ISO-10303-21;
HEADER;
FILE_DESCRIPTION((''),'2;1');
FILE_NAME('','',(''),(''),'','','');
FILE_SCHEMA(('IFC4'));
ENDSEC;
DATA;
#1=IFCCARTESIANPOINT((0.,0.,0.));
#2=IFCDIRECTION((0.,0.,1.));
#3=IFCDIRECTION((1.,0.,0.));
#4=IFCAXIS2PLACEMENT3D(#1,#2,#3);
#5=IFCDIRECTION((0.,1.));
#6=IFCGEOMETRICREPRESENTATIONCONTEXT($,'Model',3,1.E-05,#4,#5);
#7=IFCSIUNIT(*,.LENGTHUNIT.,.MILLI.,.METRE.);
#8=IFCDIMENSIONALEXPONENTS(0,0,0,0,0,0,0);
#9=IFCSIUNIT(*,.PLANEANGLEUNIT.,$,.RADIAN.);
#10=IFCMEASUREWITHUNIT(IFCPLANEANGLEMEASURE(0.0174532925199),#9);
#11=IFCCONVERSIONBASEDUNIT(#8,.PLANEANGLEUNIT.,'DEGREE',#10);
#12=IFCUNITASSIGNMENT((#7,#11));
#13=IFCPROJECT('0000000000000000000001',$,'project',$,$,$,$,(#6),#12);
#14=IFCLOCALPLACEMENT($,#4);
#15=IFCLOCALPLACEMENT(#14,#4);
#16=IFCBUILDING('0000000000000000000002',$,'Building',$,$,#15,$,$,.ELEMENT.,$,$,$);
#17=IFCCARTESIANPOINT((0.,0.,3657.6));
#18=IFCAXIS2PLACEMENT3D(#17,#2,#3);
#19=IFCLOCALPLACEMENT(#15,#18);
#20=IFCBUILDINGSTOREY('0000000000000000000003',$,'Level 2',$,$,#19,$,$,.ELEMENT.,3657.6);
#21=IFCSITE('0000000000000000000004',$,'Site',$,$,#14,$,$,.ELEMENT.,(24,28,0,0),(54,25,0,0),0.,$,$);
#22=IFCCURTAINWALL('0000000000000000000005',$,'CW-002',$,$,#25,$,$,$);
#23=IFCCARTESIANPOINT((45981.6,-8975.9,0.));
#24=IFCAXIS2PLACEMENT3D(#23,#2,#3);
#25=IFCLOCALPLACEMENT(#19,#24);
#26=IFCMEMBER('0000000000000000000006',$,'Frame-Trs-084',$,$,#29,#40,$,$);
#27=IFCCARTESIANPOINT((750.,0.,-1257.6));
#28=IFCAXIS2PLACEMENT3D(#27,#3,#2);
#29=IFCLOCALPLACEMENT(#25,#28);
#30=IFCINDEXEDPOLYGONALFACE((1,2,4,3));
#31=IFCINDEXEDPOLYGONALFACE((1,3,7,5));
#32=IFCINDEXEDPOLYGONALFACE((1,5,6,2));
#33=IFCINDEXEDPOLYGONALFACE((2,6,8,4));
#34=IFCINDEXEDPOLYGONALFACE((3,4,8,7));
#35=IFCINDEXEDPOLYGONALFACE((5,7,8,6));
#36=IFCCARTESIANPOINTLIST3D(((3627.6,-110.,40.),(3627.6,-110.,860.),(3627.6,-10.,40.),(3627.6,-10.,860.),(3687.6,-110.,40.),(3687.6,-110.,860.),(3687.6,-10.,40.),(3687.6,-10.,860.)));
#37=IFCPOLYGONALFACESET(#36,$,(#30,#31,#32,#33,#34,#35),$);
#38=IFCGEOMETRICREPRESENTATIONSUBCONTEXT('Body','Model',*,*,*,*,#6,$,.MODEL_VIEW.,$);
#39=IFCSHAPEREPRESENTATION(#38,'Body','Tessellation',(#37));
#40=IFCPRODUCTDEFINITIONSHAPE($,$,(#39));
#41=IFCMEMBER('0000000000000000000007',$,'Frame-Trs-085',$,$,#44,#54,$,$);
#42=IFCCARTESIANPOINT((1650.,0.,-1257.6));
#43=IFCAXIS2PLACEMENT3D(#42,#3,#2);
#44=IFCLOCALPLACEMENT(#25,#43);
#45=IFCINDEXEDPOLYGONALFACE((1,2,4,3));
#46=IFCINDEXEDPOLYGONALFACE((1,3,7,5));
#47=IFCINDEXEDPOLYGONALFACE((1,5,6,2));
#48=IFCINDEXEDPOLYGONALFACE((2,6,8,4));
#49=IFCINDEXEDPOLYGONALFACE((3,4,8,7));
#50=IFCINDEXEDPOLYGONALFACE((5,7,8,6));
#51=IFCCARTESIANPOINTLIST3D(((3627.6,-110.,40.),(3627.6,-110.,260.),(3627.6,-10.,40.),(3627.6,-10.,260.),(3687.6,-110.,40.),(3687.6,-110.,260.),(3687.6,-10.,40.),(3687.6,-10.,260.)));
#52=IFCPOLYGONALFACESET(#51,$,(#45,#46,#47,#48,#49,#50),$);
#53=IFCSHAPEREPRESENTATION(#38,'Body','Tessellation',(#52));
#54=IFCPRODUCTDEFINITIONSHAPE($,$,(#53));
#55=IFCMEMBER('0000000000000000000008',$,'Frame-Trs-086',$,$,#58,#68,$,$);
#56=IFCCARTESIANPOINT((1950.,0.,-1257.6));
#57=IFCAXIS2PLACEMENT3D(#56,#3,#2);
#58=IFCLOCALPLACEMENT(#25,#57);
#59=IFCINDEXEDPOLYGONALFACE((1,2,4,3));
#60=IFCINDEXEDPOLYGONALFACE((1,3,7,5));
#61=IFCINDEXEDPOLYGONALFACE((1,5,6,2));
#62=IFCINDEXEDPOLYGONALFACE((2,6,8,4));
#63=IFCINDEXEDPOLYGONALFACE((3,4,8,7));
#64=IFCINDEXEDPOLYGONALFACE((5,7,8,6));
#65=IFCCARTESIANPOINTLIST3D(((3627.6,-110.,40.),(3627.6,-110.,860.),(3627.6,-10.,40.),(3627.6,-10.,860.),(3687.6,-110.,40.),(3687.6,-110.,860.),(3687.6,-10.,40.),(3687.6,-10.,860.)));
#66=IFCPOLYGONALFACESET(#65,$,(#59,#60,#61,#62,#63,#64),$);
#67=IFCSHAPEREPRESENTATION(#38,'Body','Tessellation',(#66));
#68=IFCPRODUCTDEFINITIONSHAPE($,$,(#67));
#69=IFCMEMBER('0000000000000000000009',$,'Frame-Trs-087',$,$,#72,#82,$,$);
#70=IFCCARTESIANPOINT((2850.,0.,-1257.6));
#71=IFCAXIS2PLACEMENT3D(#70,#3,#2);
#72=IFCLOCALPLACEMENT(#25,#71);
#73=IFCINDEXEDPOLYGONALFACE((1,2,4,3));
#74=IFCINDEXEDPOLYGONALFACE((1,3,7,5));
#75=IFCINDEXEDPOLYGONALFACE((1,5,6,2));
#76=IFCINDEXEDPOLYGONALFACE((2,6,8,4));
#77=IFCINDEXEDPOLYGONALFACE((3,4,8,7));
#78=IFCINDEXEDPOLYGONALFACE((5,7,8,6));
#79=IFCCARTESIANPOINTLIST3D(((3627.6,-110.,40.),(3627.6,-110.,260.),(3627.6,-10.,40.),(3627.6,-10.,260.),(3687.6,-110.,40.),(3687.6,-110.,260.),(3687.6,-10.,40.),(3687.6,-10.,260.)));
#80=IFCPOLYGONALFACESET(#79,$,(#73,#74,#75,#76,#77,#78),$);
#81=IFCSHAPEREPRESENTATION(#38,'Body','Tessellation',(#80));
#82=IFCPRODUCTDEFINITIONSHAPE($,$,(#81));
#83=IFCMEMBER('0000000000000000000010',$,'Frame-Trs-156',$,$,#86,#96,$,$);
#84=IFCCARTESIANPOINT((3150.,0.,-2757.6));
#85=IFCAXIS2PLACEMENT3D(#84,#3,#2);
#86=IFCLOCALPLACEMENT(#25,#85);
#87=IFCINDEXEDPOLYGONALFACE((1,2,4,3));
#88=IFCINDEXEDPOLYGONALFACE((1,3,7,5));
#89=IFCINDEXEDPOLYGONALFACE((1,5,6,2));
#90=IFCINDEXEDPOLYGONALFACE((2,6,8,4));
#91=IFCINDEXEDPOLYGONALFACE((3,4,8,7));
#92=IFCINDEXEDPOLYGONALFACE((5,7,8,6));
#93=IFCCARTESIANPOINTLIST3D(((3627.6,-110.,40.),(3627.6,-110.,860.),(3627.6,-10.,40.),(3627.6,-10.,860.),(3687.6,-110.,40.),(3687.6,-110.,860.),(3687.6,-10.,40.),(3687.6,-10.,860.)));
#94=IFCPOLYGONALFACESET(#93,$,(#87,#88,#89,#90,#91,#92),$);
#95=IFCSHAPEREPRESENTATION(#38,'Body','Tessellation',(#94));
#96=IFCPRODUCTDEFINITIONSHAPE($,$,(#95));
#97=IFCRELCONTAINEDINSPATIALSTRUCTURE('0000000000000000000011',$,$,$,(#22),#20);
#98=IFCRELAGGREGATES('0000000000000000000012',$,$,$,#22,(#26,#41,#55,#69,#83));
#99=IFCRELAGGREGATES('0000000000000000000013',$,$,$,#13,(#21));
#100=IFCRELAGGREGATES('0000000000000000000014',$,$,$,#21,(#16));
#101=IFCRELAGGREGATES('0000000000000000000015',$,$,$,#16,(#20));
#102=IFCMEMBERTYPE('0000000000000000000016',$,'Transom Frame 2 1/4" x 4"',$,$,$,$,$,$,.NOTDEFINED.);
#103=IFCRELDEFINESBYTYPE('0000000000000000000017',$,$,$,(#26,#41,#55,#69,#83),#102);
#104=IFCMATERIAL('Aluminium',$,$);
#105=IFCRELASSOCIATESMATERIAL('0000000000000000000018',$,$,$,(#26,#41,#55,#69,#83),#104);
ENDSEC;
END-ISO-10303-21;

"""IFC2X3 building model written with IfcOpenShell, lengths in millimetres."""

from ifc_helpers import new_model, entity, si_unit, converted_unit, direction, frame, origin_with_axes, place, context, subcontext, project, spatial, polyline, outline, extrude, material, type_object, element, aggregate, save


model = new_model("IFC2X3")

# Units and contexts
model_context = context("Model", 3, precision=1e-05, world=origin_with_axes(), true_north=direction((0.0, 1.0)))
body_context = subcontext(model_context, "Body", "Model", "MODEL_VIEW")
ifc_project = project(units=[si_unit("LENGTHUNIT", "METRE", prefix="MILLI"), converted_unit("PLANEANGLEUNIT", "DEGREE", entity("IfcPlaneAngleMeasure", 0.0174532925199), si_unit("PLANEANGLEUNIT", "RADIAN"), dimensions=[0, 0, 0, 0, 0, 0, 0])], contexts=[model_context])

# Site, building, storey
site_placement = place(None, origin_with_axes())
site = spatial("IfcSite", under=ifc_project, at=site_placement, Name="Site", CompositionType="ELEMENT", RefLatitude=(24, 28, 0, 0), RefLongitude=(54, 25, 0, 0), RefElevation=0.0)
building_placement = place(site_placement, origin_with_axes())
building = spatial("IfcBuilding", under=site, at=building_placement, Name="Building", CompositionType="ELEMENT")
storey_placement = place(building_placement, frame((0.0, 0.0, 3657.6), z_axis=(0.0, 0.0, 1.0), x_axis=(1.0, 0.0, 0.0)))
storey = spatial("IfcBuildingStorey", under=building, at=storey_placement, Name="Level 2", CompositionType="ELEMENT", Elevation=3657.6)

# Curtain wall, members
curtain_wall_placement = place(storey_placement, frame((45981.6, -8975.9, 0.0), z_axis=(0.0, 0.0, 1.0), x_axis=(1.0, 0.0, 0.0)))
curtain_wall = element("IfcCurtainWall", 1, at=curtain_wall_placement, inside=storey, Name="CW-002")
ifc_material_1 = material(Name="Aluminium")
member_type_1 = type_object("IfcMemberType", Name="Transom Frame 2 1/4\" x 4\"", PredefinedType="NOTDEFINED")
member_1_placement = place(curtain_wall_placement, frame((750.0, 0.0, -1257.6), z_axis=(1.0, 0.0, 0.0), x_axis=(0.0, 0.0, 1.0)))
member_1 = element("IfcMember", 2, at=member_1_placement, type_object=member_type_1, material=ifc_material_1, Name="Frame-Trs-084", context=body_context, shape_type="SweptSolid", body=[
    extrude(outline(polyline([(-110.0, -3687.6), (-10.0, -3687.6), (-10.0, -3627.6), (-110.0, -3627.6), (-110.0, -3687.6)])), frame((0.0, 0.0, 40.0), z_axis=(0.0, 0.0, 1.0), x_axis=(0.0, 1.0, 0.0)), (0.0, 0.0, 1.0), 820.0),
])
member_2_placement = place(curtain_wall_placement, frame((1650.0, 0.0, -1257.6), z_axis=(1.0, 0.0, 0.0), x_axis=(0.0, 0.0, 1.0)))
member_2 = element("IfcMember", 3, at=member_2_placement, type_object=member_type_1, material=ifc_material_1, Name="Frame-Trs-085", context=body_context, shape_type="SweptSolid", body=[
    extrude(outline(polyline([(-110.0, -3687.6), (-10.0, -3687.6), (-10.0, -3627.6), (-110.0, -3627.6), (-110.0, -3687.6)])), frame((0.0, 0.0, 40.0), z_axis=(0.0, 0.0, 1.0), x_axis=(0.0, 1.0, 0.0)), (0.0, 0.0, 1.0), 220.0),
])
member_3_placement = place(curtain_wall_placement, frame((1950.0, 0.0, -1257.6), z_axis=(1.0, 0.0, 0.0), x_axis=(0.0, 0.0, 1.0)))
member_3 = element("IfcMember", 4, at=member_3_placement, type_object=member_type_1, material=ifc_material_1, Name="Frame-Trs-086", context=body_context, shape_type="SweptSolid", body=[
    extrude(outline(polyline([(-110.0, -3687.6), (-10.0, -3687.6), (-10.0, -3627.6), (-110.0, -3627.6), (-110.0, -3687.6)])), frame((0.0, 0.0, 40.0), z_axis=(0.0, 0.0, 1.0), x_axis=(0.0, 1.0, 0.0)), (0.0, 0.0, 1.0), 820.0),
])
member_4_placement = place(curtain_wall_placement, frame((2850.0, 0.0, -1257.6), z_axis=(1.0, 0.0, 0.0), x_axis=(0.0, 0.0, 1.0)))
member_4 = element("IfcMember", 5, at=member_4_placement, type_object=member_type_1, material=ifc_material_1, Name="Frame-Trs-087", context=body_context, shape_type="SweptSolid", body=[
    extrude(outline(polyline([(-110.0, -3687.6), (-10.0, -3687.6), (-10.0, -3627.6), (-110.0, -3627.6), (-110.0, -3687.6)])), frame((0.0, 0.0, 40.0), z_axis=(0.0, 0.0, 1.0), x_axis=(0.0, 1.0, 0.0)), (0.0, 0.0, 1.0), 220.0),
])
member_5_placement = place(curtain_wall_placement, frame((3150.0, 0.0, -2757.6), z_axis=(1.0, 0.0, 0.0), x_axis=(0.0, 0.0, 1.0)))
member_5 = element("IfcMember", 6, at=member_5_placement, type_object=member_type_1, material=ifc_material_1, Name="Frame-Trs-156", context=body_context, shape_type="SweptSolid", body=[
    extrude(outline(polyline([(-110.0, -3687.6), (-10.0, -3687.6), (-10.0, -3627.6), (-110.0, -3627.6), (-110.0, -3687.6)])), frame((0.0, 0.0, 40.0), z_axis=(0.0, 0.0, 1.0), x_axis=(0.0, 1.0, 0.0)), (0.0, 0.0, 1.0), 820.0),
])
aggregate(curtain_wall, [member_1, member_2, member_3, member_4, member_5])

save(model, "model.ifc")
